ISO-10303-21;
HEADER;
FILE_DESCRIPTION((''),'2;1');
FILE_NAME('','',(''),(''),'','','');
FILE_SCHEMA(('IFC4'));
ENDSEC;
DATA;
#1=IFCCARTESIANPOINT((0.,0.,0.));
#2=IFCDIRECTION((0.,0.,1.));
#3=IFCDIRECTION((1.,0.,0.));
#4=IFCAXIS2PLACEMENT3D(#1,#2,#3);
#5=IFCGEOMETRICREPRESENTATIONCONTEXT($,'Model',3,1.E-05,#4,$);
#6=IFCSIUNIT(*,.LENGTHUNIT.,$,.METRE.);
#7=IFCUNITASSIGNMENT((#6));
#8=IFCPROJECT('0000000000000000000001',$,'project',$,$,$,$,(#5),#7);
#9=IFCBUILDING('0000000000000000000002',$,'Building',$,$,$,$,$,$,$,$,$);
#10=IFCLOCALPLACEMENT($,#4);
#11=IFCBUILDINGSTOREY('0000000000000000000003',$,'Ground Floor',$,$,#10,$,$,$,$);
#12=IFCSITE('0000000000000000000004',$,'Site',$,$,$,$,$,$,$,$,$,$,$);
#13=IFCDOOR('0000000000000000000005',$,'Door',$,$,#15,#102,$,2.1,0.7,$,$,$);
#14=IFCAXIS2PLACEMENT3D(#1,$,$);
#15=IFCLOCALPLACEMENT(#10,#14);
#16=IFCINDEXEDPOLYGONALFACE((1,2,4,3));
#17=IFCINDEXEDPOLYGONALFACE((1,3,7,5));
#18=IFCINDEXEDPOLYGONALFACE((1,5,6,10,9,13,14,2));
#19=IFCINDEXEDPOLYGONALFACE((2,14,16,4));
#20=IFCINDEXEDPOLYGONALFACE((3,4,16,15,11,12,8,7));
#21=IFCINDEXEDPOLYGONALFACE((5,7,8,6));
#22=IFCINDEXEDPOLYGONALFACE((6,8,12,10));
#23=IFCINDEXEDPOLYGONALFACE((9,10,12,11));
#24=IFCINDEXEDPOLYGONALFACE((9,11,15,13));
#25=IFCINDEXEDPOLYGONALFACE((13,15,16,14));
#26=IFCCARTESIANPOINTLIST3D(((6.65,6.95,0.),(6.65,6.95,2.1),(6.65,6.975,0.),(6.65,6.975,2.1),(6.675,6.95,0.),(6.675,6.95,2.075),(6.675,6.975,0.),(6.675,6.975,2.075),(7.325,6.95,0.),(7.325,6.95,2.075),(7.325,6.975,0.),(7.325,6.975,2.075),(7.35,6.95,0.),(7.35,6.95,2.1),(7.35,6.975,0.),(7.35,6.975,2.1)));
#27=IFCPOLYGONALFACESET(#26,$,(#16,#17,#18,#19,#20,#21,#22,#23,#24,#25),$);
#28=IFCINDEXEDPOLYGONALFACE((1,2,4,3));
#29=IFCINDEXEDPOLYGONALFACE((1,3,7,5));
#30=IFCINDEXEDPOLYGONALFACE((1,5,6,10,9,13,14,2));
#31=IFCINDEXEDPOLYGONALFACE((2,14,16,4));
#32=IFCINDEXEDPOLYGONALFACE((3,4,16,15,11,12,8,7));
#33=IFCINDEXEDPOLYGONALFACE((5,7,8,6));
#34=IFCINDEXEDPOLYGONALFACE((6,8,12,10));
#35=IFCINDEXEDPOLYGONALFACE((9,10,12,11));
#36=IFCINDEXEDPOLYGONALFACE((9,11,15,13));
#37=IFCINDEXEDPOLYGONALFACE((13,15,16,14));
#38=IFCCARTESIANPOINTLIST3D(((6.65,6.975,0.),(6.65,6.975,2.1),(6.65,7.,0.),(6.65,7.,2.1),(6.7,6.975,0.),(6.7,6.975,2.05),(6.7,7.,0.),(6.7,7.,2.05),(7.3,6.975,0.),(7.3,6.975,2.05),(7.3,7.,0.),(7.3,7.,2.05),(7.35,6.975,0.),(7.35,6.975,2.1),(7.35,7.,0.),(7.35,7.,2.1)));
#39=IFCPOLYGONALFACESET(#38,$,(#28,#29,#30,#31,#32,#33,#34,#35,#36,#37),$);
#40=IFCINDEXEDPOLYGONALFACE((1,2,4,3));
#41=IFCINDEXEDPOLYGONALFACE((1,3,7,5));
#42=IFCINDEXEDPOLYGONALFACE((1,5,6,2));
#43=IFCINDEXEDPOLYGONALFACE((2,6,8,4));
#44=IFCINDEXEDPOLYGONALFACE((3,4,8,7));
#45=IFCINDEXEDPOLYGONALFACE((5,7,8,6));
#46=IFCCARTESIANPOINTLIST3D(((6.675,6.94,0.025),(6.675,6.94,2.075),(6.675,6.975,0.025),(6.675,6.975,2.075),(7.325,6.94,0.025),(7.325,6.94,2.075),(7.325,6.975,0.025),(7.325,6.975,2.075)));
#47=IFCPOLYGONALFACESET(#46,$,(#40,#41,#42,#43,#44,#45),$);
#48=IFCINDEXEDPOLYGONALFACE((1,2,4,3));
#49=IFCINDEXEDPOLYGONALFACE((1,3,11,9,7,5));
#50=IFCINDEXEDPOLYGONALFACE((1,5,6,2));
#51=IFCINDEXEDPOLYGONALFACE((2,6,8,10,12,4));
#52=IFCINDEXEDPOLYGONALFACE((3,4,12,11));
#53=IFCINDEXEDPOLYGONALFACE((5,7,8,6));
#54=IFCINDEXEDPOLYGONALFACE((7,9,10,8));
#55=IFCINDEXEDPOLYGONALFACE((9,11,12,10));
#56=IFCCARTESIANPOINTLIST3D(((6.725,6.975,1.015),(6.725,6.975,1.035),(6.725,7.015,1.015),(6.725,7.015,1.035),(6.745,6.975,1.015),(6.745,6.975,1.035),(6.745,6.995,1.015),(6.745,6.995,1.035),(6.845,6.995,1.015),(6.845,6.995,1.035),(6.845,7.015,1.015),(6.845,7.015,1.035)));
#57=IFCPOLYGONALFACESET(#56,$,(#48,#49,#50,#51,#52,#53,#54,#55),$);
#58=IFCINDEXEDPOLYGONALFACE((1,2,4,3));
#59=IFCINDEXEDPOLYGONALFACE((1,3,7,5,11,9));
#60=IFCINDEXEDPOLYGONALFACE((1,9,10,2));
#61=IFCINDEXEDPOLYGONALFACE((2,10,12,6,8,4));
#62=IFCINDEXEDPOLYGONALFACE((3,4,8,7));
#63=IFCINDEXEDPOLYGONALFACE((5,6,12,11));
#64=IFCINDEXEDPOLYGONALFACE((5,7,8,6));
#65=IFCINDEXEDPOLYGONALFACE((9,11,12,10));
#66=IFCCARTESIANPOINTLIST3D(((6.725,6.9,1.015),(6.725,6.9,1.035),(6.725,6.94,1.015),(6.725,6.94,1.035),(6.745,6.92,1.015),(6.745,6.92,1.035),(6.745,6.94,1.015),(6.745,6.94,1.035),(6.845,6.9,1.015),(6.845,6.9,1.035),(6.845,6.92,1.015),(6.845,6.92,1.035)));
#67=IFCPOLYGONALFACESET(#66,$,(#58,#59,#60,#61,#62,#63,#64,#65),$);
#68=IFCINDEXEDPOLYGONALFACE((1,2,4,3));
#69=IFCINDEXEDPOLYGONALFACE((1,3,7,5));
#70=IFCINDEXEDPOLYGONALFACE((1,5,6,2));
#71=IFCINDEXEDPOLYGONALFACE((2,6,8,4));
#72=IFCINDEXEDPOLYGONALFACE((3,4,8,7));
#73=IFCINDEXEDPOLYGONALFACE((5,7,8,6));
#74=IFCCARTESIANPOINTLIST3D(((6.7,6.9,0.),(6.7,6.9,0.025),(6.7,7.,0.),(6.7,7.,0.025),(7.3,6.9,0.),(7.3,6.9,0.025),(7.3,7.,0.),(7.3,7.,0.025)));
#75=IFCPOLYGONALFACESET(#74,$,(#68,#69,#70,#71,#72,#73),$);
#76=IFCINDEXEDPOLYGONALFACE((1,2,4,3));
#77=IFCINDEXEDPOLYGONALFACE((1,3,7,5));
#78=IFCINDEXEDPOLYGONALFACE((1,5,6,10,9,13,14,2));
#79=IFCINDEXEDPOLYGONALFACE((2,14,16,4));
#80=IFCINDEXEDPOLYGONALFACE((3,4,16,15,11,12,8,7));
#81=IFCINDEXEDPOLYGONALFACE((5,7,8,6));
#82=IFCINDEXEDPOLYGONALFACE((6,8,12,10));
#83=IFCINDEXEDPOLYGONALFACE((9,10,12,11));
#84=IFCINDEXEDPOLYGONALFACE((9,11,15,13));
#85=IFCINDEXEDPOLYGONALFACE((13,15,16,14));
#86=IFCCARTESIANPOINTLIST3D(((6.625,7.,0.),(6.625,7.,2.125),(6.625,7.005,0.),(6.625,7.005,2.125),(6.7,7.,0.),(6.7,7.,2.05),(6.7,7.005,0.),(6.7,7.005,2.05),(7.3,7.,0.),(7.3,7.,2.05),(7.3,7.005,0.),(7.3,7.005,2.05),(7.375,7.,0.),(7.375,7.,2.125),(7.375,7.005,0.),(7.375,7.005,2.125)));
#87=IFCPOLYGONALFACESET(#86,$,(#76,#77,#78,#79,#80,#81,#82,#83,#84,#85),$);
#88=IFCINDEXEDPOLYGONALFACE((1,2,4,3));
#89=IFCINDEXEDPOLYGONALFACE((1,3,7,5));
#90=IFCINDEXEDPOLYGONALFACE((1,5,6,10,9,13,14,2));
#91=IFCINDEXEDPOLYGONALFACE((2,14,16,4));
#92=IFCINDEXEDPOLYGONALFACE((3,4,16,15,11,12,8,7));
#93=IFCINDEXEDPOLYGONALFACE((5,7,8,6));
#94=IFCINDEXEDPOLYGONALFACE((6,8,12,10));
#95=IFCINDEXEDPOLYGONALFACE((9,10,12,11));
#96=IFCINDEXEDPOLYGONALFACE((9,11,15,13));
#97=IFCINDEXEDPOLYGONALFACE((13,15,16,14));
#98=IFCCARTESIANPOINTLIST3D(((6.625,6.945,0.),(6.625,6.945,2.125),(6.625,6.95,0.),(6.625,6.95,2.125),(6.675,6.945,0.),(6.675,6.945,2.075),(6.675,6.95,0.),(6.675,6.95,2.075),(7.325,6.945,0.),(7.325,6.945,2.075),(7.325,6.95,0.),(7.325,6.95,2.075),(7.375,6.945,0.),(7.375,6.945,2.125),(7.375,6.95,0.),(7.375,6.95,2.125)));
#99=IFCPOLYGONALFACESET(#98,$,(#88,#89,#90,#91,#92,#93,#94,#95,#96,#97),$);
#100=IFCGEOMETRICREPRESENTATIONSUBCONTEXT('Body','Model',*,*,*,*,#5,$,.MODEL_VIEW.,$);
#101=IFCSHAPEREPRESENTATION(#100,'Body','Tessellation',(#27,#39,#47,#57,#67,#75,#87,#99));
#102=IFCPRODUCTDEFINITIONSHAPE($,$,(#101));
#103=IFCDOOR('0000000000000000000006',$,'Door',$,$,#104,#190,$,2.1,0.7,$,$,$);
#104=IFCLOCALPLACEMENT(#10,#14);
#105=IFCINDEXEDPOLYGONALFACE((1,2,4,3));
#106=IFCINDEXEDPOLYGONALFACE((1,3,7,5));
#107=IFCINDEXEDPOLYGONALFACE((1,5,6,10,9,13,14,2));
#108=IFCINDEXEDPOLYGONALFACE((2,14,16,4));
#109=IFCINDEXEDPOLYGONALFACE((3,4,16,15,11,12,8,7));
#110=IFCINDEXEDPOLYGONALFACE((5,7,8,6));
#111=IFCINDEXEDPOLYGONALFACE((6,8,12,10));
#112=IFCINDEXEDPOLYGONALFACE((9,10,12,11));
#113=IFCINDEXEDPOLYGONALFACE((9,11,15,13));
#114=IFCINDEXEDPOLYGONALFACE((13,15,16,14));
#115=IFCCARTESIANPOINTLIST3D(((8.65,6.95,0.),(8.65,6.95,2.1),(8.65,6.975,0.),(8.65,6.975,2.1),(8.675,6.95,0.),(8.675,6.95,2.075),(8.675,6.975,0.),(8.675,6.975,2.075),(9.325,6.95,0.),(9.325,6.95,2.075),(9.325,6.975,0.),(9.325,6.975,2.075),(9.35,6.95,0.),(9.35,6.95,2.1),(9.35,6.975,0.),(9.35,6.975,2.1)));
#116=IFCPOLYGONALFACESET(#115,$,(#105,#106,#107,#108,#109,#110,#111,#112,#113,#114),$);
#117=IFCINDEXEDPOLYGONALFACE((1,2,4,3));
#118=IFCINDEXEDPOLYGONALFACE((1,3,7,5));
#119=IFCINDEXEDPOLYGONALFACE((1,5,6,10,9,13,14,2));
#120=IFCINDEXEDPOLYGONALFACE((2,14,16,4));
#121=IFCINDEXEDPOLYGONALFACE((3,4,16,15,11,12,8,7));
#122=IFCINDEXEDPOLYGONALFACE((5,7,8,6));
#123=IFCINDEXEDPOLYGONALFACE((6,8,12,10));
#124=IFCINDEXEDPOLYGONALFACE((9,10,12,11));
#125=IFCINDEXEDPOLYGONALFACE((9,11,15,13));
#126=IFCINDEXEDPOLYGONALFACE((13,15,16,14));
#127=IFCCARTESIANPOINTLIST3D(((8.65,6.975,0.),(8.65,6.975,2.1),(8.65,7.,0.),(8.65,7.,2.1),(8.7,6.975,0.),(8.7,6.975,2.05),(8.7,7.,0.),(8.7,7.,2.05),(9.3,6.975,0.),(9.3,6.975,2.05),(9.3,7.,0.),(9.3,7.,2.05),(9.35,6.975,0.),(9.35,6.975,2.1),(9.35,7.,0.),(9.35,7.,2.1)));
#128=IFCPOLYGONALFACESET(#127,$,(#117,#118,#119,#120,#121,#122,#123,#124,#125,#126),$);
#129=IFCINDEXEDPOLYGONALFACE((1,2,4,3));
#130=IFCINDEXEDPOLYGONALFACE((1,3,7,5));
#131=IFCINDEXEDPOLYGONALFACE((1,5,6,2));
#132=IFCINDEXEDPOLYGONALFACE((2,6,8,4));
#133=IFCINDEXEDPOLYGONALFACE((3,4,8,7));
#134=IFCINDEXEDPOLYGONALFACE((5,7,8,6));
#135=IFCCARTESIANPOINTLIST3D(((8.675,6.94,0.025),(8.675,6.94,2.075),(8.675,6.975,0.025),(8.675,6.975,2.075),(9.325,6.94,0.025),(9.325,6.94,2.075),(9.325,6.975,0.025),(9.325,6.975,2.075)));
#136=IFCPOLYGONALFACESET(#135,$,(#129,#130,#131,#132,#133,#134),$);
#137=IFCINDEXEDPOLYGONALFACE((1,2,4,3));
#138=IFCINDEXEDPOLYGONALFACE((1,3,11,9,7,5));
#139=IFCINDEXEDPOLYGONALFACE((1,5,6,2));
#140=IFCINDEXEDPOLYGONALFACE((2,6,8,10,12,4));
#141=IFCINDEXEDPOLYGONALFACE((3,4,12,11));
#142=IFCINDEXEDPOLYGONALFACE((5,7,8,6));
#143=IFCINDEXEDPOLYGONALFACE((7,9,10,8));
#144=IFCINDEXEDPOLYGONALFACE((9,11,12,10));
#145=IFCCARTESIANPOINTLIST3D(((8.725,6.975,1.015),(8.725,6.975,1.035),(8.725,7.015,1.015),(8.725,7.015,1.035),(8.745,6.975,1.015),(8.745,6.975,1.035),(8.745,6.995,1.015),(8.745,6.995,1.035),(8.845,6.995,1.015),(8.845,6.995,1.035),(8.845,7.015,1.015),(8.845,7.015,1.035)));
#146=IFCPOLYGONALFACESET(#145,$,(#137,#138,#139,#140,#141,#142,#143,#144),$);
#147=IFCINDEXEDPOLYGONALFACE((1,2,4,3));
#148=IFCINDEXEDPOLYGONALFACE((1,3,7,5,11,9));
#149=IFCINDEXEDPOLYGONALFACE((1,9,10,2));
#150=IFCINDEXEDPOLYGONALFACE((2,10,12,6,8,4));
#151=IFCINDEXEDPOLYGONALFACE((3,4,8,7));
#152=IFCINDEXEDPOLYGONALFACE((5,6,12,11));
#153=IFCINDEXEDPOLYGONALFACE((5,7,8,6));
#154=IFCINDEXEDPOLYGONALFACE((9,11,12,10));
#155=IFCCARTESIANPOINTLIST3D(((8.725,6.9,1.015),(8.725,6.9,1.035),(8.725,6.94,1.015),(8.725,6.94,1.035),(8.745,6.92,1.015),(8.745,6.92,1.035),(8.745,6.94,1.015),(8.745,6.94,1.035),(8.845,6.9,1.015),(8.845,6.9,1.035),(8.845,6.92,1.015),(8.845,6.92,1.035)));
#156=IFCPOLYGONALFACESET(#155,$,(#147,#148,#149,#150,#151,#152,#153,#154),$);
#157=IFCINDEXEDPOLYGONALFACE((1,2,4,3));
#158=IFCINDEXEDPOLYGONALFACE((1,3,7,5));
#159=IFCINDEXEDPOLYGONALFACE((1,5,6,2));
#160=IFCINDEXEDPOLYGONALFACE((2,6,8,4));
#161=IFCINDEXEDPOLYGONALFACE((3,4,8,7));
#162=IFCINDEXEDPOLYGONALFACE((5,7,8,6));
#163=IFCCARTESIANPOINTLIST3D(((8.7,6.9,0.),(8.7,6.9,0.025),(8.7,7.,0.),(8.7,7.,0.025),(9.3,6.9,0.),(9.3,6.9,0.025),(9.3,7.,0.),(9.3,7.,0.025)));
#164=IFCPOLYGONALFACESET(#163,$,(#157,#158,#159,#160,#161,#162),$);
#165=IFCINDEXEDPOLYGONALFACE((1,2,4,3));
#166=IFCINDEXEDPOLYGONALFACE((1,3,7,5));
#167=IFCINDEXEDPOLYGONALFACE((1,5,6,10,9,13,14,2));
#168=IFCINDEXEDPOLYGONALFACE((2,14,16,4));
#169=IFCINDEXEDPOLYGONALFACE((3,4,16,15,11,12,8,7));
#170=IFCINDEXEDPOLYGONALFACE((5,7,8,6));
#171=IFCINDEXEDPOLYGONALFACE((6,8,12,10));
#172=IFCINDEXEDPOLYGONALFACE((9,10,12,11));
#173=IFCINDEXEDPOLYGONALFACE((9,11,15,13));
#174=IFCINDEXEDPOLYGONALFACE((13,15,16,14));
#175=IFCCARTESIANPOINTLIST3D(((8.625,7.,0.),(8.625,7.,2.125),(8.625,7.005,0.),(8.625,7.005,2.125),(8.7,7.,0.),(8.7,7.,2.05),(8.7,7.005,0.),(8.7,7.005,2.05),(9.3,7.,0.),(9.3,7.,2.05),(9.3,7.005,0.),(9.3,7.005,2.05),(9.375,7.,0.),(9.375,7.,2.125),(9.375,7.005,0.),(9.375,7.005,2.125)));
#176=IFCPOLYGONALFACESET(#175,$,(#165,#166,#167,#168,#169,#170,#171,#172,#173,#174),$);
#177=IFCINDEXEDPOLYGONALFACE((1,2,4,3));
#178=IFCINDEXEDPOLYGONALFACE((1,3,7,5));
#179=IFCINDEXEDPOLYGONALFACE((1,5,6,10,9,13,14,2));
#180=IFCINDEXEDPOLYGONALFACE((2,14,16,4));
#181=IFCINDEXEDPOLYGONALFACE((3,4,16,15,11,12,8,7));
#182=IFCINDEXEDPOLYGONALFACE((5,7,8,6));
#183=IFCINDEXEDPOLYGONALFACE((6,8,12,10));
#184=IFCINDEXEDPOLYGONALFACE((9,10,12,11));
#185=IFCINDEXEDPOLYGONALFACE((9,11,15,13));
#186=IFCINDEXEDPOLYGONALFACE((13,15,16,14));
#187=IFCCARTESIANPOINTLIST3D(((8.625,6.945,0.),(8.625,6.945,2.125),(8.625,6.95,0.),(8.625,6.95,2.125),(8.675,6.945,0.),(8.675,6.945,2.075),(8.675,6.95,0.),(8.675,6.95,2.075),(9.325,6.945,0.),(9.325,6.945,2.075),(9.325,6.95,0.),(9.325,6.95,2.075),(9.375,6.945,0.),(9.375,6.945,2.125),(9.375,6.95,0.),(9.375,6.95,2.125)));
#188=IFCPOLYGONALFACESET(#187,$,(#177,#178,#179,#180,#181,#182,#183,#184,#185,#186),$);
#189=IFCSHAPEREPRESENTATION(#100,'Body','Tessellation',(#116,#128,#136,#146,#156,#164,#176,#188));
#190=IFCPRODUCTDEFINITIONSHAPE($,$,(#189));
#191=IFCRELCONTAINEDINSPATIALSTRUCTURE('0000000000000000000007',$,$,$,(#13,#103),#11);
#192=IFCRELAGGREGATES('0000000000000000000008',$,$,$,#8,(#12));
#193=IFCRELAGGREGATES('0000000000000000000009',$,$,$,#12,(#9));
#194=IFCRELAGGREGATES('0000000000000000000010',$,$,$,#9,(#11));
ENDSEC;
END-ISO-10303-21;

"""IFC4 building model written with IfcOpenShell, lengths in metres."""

from ifc_helpers import new_model, si_unit, frame, origin_with_axes, place, context, subcontext, project, spatial, line, indexed_curve, outline, extrude, element, save


model = new_model("IFC4")

# Units and contexts
model_context = context("Model", 3, precision=1e-05, world=origin_with_axes())
body_context = subcontext(model_context, "Body", "Model", "MODEL_VIEW")
ifc_project = project(units=[si_unit("LENGTHUNIT", "METRE")], contexts=[model_context])

# Site, building, storey
site = spatial("IfcSite", under=ifc_project, Name="Site")
building = spatial("IfcBuilding", under=site, Name="Building")
storey_placement = place(None, origin_with_axes())
storey = spatial("IfcBuildingStorey", under=building, at=storey_placement, Name="Ground Floor")

# Doors
door_1_placement = place(storey_placement, frame((7.35, 7.0, 0.0), z_axis=(0.0, 0.0, 1.0), x_axis=(-1.0, 0.0, 0.0)))
element("IfcDoor", 1, at=door_1_placement, inside=storey, Name="Door", OverallHeight=2.1, OverallWidth=0.7, context=body_context, shape_type="SweptSolid", body=[
    extrude(outline(indexed_curve([(0.0, 0.0), (0.0, 2.1), (0.7, 2.1), (0.7, 0.0), (0.675, 0.0), (0.675, 2.075), (0.025, 2.075), (0.025, 0.0)], segments=[line(1, 2, 3, 4, 5, 6, 7, 8, 1)])), frame((0.0, 0.025, 0.0), z_axis=(0.0, -1.0, 0.0), x_axis=(1.0, 0.0, 0.0)), (0.0, 0.0, -1.0), 0.025),
    extrude(outline(indexed_curve([(0.0, 0.0), (0.0, 2.1), (0.7, 2.1), (0.7, 0.0), (0.65, 0.0), (0.65, 2.05), (0.05, 2.05), (0.05, 0.0)], segments=[line(1, 2, 3, 4, 5, 6, 7, 8, 1)])), frame((0.0, 0.0, 0.0), z_axis=(0.0, -1.0, 0.0), x_axis=(1.0, 0.0, 0.0)), (0.0, 0.0, -1.0), 0.025),
    extrude(outline(indexed_curve([(0.0, 0.0), (0.65, 0.0), (0.65, 0.035), (0.0, 0.035)], segments=[line(1, 2, 3, 4, 1)])), frame((0.025, 0.025, 0.025), z_axis=(0.0, 0.0, 1.0), x_axis=(1.0, 0.0, 0.0)), (0.0, 0.0, 1.0), 2.05),
    extrude(outline(indexed_curve([(0.0, 0.0), (0.0, -0.04), (-0.12, -0.04), (-0.12, -0.02), (-0.02, -0.02), (-0.02, 0.0)], segments=[line(1, 2, 3, 4, 5, 6, 1)])), frame((0.625, 0.025, 1.015), z_axis=(0.0, 0.0, 1.0), x_axis=(1.0, 0.0, 0.0)), (0.0, 0.0, 1.0), 0.02),
    extrude(outline(indexed_curve([(0.0, 0.0), (0.0, 0.04), (-0.12, 0.04), (-0.12, 0.02), (-0.02, 0.02), (-0.02, 0.0)], segments=[line(1, 2, 3, 4, 5, 6, 1)])), frame((0.625, 0.06, 1.015), z_axis=(0.0, 0.0, 1.0), x_axis=(1.0, 0.0, 0.0)), (0.0, 0.0, 1.0), 0.02),
    extrude(outline(indexed_curve([(0.0, 0.0), (0.6, 0.0), (0.6, 0.1), (0.0, 0.1)], segments=[line(1, 2, 3, 4, 1)])), frame((0.05, 0.0, 0.0), z_axis=(0.0, 0.0, 1.0), x_axis=(1.0, 0.0, 0.0)), (0.0, 0.0, 1.0), 0.025),
    extrude(outline(indexed_curve([(0.0, 0.0), (0.0, 2.125), (0.75, 2.125), (0.75, 0.0), (0.675, 0.0), (0.675, 2.05), (0.075, 2.05), (0.075, 0.0)], segments=[line(1, 2, 3, 4, 5, 6, 7, 8, 1)])), frame((-0.025, -0.005, 0.0), z_axis=(0.0, -1.0, 0.0), x_axis=(1.0, 0.0, 0.0)), (0.0, 0.0, -1.0), 0.005),
    extrude(outline(indexed_curve([(0.0, 0.0), (0.0, 2.125), (0.75, 2.125), (0.75, 0.0), (0.7, 0.0), (0.7, 2.075), (0.05, 2.075), (0.05, 0.0)], segments=[line(1, 2, 3, 4, 5, 6, 7, 8, 1)])), frame((-0.025, 0.05, 0.0), z_axis=(0.0, -1.0, 0.0), x_axis=(1.0, 0.0, 0.0)), (0.0, 0.0, -1.0), 0.005),
])
door_2_placement = place(storey_placement, frame((9.35, 7.0, 0.0), z_axis=(0.0, 0.0, 1.0), x_axis=(-1.0, 0.0, 0.0)))
element("IfcDoor", 2, at=door_2_placement, inside=storey, Name="Door", OverallHeight=2.1, OverallWidth=0.7, context=body_context, shape_type="SweptSolid", body=[
    extrude(outline(indexed_curve([(0.0, 0.0), (0.0, 2.1), (0.7, 2.1), (0.7, 0.0), (0.675, 0.0), (0.675, 2.075), (0.025, 2.075), (0.025, 0.0)], segments=[line(1, 2, 3, 4, 5, 6, 7, 8, 1)])), frame((0.0, 0.025, 0.0), z_axis=(0.0, -1.0, 0.0), x_axis=(1.0, 0.0, 0.0)), (0.0, 0.0, -1.0), 0.025),
    extrude(outline(indexed_curve([(0.0, 0.0), (0.0, 2.1), (0.7, 2.1), (0.7, 0.0), (0.65, 0.0), (0.65, 2.05), (0.05, 2.05), (0.05, 0.0)], segments=[line(1, 2, 3, 4, 5, 6, 7, 8, 1)])), frame((0.0, 0.0, 0.0), z_axis=(0.0, -1.0, 0.0), x_axis=(1.0, 0.0, 0.0)), (0.0, 0.0, -1.0), 0.025),
    extrude(outline(indexed_curve([(0.0, 0.0), (0.65, 0.0), (0.65, 0.035), (0.0, 0.035)], segments=[line(1, 2, 3, 4, 1)])), frame((0.025, 0.025, 0.025), z_axis=(0.0, 0.0, 1.0), x_axis=(1.0, 0.0, 0.0)), (0.0, 0.0, 1.0), 2.05),
    extrude(outline(indexed_curve([(0.0, 0.0), (0.0, -0.04), (-0.12, -0.04), (-0.12, -0.02), (-0.02, -0.02), (-0.02, 0.0)], segments=[line(1, 2, 3, 4, 5, 6, 1)])), frame((0.625, 0.025, 1.015), z_axis=(0.0, 0.0, 1.0), x_axis=(1.0, 0.0, 0.0)), (0.0, 0.0, 1.0), 0.02),
    extrude(outline(indexed_curve([(0.0, 0.0), (0.0, 0.04), (-0.12, 0.04), (-0.12, 0.02), (-0.02, 0.02), (-0.02, 0.0)], segments=[line(1, 2, 3, 4, 5, 6, 1)])), frame((0.625, 0.06, 1.015), z_axis=(0.0, 0.0, 1.0), x_axis=(1.0, 0.0, 0.0)), (0.0, 0.0, 1.0), 0.02),
    extrude(outline(indexed_curve([(0.0, 0.0), (0.6, 0.0), (0.6, 0.1), (0.0, 0.1)], segments=[line(1, 2, 3, 4, 1)])), frame((0.05, 0.0, 0.0), z_axis=(0.0, 0.0, 1.0), x_axis=(1.0, 0.0, 0.0)), (0.0, 0.0, 1.0), 0.025),
    extrude(outline(indexed_curve([(0.0, 0.0), (0.0, 2.125), (0.75, 2.125), (0.75, 0.0), (0.675, 0.0), (0.675, 2.05), (0.075, 2.05), (0.075, 0.0)], segments=[line(1, 2, 3, 4, 5, 6, 7, 8, 1)])), frame((-0.025, -0.005, 0.0), z_axis=(0.0, -1.0, 0.0), x_axis=(1.0, 0.0, 0.0)), (0.0, 0.0, -1.0), 0.005),
    extrude(outline(indexed_curve([(0.0, 0.0), (0.0, 2.125), (0.75, 2.125), (0.75, 0.0), (0.7, 0.0), (0.7, 2.075), (0.05, 2.075), (0.05, 0.0)], segments=[line(1, 2, 3, 4, 5, 6, 7, 8, 1)])), frame((-0.025, 0.05, 0.0), z_axis=(0.0, -1.0, 0.0), x_axis=(1.0, 0.0, 0.0)), (0.0, 0.0, -1.0), 0.005),
])

save(model, "model.ifc")
